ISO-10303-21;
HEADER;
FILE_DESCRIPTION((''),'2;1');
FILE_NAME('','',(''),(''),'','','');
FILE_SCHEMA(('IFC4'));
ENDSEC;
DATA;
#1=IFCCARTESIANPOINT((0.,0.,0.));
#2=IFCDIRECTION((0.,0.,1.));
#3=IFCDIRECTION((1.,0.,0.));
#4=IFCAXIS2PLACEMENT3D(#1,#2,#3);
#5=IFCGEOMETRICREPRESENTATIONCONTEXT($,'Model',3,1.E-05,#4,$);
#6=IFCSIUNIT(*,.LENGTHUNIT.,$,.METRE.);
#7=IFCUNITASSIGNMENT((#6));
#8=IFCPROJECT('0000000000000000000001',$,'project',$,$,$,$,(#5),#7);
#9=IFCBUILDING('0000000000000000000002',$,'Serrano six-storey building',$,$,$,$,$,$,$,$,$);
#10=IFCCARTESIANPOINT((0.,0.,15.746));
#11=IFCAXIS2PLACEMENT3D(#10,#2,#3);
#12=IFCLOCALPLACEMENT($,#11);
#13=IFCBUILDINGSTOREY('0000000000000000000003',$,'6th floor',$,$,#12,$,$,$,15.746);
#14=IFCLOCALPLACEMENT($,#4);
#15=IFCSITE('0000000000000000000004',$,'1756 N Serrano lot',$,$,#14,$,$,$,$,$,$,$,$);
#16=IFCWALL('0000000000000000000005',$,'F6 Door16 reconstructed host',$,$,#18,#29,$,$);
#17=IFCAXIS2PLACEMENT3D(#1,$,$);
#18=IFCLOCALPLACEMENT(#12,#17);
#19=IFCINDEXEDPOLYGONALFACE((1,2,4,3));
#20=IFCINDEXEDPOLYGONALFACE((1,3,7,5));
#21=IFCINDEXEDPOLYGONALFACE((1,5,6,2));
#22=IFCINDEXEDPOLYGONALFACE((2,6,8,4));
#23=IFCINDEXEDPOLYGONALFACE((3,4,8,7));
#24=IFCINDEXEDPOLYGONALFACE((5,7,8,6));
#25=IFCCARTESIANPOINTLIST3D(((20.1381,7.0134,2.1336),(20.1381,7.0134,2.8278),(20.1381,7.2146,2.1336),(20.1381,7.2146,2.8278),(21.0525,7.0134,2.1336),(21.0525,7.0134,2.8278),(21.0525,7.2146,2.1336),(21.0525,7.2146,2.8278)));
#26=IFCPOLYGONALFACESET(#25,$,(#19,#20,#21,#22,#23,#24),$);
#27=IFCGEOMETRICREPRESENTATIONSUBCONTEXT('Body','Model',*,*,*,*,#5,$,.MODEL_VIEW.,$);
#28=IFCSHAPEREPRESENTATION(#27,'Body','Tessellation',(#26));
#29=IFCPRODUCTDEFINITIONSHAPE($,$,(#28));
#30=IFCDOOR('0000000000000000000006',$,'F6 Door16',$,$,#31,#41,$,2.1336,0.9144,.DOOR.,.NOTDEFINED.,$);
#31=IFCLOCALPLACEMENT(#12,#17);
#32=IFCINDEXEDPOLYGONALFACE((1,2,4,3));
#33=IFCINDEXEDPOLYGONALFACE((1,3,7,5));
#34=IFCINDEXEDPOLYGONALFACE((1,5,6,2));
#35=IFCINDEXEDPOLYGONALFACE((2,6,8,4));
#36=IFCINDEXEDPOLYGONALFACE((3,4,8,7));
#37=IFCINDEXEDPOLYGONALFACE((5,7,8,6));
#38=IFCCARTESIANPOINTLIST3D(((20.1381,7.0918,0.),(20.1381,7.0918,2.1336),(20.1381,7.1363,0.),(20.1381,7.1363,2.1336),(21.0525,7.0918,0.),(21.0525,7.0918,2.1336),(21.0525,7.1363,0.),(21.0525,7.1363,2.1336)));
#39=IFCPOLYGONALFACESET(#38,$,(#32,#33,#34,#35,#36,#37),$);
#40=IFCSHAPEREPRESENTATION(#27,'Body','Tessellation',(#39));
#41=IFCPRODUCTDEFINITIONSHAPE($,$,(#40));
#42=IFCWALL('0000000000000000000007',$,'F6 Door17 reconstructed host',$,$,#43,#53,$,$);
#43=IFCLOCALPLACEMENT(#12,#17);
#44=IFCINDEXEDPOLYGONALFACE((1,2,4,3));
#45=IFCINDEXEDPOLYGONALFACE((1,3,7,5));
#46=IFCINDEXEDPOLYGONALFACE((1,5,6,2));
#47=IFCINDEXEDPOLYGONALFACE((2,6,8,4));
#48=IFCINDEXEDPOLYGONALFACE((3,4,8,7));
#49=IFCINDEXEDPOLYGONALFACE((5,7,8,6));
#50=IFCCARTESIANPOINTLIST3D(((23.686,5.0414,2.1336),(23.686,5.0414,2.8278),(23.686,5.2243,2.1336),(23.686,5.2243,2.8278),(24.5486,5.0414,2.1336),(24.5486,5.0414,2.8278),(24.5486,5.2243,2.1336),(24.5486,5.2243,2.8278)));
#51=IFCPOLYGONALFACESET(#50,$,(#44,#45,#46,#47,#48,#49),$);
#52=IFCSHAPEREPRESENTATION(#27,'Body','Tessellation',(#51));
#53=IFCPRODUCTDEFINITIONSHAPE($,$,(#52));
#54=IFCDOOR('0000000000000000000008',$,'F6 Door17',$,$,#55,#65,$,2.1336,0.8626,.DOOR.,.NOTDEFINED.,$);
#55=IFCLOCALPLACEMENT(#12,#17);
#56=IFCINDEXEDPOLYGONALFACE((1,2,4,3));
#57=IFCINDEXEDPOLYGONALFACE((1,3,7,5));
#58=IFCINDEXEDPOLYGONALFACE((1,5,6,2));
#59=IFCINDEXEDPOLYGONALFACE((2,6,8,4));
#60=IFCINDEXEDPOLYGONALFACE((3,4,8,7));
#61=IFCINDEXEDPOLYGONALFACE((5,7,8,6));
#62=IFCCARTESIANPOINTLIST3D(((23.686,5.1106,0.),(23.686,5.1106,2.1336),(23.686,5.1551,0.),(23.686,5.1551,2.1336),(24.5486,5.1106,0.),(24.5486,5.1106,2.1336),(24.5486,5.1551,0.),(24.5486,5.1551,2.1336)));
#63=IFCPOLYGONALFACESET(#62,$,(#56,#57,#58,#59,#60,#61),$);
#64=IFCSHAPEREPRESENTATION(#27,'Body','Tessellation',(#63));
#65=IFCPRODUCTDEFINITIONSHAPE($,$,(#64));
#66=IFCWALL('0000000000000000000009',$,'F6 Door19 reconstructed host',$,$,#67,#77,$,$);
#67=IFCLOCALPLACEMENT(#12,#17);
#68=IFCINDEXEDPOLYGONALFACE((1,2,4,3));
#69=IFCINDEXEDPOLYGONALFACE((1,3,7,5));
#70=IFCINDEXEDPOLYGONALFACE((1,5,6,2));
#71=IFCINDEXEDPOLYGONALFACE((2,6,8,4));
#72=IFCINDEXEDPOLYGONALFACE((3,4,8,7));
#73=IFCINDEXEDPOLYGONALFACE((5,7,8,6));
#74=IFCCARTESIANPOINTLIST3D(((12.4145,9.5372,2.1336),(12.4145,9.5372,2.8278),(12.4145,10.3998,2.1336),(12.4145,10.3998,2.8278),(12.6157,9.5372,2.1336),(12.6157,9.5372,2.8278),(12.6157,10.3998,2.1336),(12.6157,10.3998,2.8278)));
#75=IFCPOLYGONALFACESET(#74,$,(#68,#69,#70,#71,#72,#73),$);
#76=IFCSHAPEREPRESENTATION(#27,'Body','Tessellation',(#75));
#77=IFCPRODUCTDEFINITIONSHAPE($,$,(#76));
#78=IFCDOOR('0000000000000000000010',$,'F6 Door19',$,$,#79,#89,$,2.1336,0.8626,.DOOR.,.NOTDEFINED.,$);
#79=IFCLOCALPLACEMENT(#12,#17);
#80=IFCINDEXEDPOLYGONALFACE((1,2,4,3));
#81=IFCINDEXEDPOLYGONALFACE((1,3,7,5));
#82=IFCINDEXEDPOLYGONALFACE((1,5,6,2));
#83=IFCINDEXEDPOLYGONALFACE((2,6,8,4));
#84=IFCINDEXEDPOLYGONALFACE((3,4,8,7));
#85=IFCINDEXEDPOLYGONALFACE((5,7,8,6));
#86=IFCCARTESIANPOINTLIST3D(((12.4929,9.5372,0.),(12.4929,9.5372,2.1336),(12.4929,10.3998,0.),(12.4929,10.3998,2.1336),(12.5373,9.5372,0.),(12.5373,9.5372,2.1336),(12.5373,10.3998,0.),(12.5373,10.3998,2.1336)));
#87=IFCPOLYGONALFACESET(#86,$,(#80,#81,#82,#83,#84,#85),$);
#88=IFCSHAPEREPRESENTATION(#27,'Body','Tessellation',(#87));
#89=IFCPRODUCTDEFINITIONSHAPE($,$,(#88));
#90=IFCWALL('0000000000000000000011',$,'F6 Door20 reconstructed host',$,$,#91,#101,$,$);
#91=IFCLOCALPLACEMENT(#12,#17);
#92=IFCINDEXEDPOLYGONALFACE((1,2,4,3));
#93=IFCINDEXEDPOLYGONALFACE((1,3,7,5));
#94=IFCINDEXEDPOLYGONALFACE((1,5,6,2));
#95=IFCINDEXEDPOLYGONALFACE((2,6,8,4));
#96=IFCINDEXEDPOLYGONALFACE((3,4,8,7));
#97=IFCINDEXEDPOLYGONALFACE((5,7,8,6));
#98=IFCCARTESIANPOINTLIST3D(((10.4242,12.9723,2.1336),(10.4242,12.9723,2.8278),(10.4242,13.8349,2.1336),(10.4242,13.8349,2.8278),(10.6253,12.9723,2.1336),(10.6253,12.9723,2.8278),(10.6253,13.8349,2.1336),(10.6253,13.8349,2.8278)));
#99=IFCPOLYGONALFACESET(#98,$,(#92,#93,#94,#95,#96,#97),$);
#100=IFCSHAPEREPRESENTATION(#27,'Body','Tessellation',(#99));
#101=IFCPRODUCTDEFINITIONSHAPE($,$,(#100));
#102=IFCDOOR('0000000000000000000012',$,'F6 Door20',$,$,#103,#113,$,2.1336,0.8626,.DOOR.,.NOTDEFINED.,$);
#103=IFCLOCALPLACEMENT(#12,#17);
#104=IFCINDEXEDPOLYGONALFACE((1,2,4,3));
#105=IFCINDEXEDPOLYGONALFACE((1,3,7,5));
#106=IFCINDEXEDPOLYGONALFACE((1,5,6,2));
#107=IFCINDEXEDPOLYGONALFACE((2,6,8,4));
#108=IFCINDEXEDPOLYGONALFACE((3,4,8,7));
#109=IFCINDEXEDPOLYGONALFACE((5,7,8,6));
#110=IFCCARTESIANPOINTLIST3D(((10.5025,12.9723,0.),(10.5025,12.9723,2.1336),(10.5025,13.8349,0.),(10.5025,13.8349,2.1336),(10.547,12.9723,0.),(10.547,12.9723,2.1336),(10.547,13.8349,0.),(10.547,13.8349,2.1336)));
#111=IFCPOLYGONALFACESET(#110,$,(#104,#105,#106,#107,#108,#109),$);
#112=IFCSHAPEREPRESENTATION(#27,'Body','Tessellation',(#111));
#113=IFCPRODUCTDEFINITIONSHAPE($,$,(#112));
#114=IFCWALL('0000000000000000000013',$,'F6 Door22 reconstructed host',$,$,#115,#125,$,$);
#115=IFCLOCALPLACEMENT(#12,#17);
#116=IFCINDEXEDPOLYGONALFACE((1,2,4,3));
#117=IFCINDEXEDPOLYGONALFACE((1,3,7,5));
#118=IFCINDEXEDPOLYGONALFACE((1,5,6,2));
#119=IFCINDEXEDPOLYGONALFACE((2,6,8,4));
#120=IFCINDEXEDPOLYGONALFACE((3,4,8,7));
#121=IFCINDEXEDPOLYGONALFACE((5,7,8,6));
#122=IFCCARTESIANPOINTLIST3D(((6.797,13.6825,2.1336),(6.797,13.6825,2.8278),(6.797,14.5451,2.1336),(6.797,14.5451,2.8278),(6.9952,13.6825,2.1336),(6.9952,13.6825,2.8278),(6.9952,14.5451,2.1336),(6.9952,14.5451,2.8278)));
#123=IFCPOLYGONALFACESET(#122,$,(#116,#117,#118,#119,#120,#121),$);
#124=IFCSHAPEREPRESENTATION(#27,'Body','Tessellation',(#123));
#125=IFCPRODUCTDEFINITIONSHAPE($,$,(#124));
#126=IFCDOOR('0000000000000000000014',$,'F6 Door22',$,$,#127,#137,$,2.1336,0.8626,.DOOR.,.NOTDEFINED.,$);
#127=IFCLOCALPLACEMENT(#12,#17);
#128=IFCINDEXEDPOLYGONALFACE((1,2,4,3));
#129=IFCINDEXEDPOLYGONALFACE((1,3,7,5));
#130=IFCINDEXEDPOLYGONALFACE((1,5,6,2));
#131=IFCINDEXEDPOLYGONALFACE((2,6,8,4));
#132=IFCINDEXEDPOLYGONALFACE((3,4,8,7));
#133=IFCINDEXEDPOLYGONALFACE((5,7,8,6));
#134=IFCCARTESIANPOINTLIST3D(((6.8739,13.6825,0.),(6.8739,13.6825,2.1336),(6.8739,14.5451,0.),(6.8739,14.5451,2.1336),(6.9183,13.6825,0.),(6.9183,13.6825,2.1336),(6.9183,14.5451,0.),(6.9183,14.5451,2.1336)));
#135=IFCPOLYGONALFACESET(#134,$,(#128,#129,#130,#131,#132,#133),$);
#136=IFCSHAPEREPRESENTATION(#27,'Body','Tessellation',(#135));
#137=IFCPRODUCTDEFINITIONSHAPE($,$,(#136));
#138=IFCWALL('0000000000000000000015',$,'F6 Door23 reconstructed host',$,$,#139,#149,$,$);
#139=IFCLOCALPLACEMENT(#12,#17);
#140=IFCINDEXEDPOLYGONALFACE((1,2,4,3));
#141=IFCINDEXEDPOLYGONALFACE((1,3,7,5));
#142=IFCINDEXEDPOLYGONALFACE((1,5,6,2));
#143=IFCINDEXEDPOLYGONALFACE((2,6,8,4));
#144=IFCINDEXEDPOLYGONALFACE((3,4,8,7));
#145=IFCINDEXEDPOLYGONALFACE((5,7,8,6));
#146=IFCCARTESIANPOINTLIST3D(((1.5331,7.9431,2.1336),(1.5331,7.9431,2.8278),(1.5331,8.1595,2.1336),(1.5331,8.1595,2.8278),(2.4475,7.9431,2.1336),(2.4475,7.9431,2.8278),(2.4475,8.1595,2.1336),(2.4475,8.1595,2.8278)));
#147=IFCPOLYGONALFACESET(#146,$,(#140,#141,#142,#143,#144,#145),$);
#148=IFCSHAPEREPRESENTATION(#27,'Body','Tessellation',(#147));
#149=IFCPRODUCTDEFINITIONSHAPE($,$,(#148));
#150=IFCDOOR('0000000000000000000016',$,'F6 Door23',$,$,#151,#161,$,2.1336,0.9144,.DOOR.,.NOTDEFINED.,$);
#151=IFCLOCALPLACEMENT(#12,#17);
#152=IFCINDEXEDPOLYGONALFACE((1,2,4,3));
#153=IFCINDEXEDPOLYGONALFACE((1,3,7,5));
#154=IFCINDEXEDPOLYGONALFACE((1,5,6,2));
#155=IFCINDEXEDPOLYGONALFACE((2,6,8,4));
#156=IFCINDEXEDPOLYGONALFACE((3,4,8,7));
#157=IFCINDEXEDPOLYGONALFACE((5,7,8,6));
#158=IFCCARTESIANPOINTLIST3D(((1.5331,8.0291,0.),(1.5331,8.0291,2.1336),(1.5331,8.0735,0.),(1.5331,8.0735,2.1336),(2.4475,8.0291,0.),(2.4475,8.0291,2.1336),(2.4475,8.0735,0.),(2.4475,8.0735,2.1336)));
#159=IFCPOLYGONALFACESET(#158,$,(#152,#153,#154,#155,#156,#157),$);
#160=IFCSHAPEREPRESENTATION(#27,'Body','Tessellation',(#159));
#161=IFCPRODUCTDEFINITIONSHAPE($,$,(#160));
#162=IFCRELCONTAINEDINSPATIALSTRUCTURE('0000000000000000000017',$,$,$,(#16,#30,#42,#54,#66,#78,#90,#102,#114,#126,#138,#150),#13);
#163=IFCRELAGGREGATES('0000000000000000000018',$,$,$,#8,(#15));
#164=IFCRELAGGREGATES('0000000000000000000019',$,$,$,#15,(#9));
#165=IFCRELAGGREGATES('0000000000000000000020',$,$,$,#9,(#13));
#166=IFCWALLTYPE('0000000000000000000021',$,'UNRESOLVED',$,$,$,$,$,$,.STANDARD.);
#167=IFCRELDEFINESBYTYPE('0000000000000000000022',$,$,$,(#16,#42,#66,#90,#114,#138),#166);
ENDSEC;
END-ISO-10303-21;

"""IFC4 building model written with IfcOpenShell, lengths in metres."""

from ifc_helpers import new_model, si_unit, frame, origin_with_axes, place, context, subcontext, project, spatial, polyline, outline, extrude, type_object, element, fill, save


model = new_model("IFC4")

# Units and contexts
model_context = context("Model", 3, precision=1e-05, world=origin_with_axes())
body_context = subcontext(model_context, "Body", "Model", "MODEL_VIEW")
ifc_project = project(units=[si_unit("LENGTHUNIT", "METRE")], contexts=[model_context])

# Site, building, storey
site_placement = place(None, origin_with_axes())
site = spatial("IfcSite", under=ifc_project, at=site_placement, Name="1756 N Serrano lot")
building = spatial("IfcBuilding", under=site, Name="Serrano six-storey building")
storey_placement = place(None, frame((0.0, 0.0, 15.746), z_axis=(0.0, 0.0, 1.0), x_axis=(1.0, 0.0, 0.0)))
storey = spatial("IfcBuildingStorey", under=building, at=storey_placement, Name="6th floor", Elevation=15.746)

# Walls, openings, doors
wall_type_1 = type_object("IfcWallType", Name="UNRESOLVED", PredefinedType="STANDARD")
wall_1_placement = place(storey_placement, frame((0.0, 0.0, -15.746), z_axis=(0.0, 0.0, 1.0), x_axis=(1.0, 0.0, 0.0)))
wall_1 = element("IfcWall", 1, at=wall_1_placement, inside=storey, type_object=wall_type_1, Name="F6 Door16 reconstructed host", context=body_context, shape_type="SweptSolid", body=[
    extrude(outline(polyline([(21.0525, 7.2146), (21.0525, 7.0134), (20.1381, 7.0134), (20.1381, 7.2146), (21.0525, 7.2146)])), frame((0.0, 0.0, 15.746)), (0.0, 0.0, 1.0), 2.8278),
])
opening_1_placement = place(None, origin_with_axes())
opening_1 = element("IfcOpeningElement", 2, at=opening_1_placement, cuts=wall_1, PredefinedType="OPENING", context=body_context, shape_type="SweptSolid", body=[
    extrude(outline(polyline([(21.0525, 7.2329), (21.0525, 6.9952), (20.1381, 6.9952), (20.1381, 7.2329), (21.0525, 7.2329)])), frame((0.0, 0.0, 15.746)), (0.0, 0.0, 1.0), 2.1336),
])
door_1_placement = place(storey_placement, frame((0.0, 0.0, -15.746), z_axis=(0.0, 0.0, 1.0), x_axis=(1.0, 0.0, 0.0)))
door_1 = element("IfcDoor", 3, at=door_1_placement, inside=storey, Name="F6 Door16", OperationType="NOTDEFINED", OverallHeight=2.1336, OverallWidth=0.9144, PredefinedType="DOOR", context=body_context, shape_type="SweptSolid", body=[
    extrude(outline(polyline([(21.0525, 7.1363), (21.0525, 7.0918), (20.1381, 7.0918), (20.1381, 7.1363), (21.0525, 7.1363)])), frame((0.0, 0.0, 15.746)), (0.0, 0.0, 1.0), 2.1336),
])
fill(opening_1, door_1)
wall_2_placement = place(storey_placement, frame((0.0, 0.0, -15.746), z_axis=(0.0, 0.0, 1.0), x_axis=(1.0, 0.0, 0.0)))
wall_2 = element("IfcWall", 4, at=wall_2_placement, inside=storey, type_object=wall_type_1, Name="F6 Door17 reconstructed host", context=body_context, shape_type="SweptSolid", body=[
    extrude(outline(polyline([(23.686, 5.0414), (23.686, 5.2243), (24.5486, 5.2243), (24.5486, 5.0414), (23.686, 5.0414)])), frame((0.0, 0.0, 15.746)), (0.0, 0.0, 1.0), 2.8278),
])
opening_2_placement = place(None, origin_with_axes())
opening_2 = element("IfcOpeningElement", 5, at=opening_2_placement, cuts=wall_2, PredefinedType="OPENING", context=body_context, shape_type="SweptSolid", body=[
    extrude(outline(polyline([(23.686, 5.0231), (23.686, 5.2426), (24.5486, 5.2426), (24.5486, 5.0231), (23.686, 5.0231)])), frame((0.0, 0.0, 15.746)), (0.0, 0.0, 1.0), 2.1336),
])
door_2_placement = place(storey_placement, frame((0.0, 0.0, -15.746), z_axis=(0.0, 0.0, 1.0), x_axis=(1.0, 0.0, 0.0)))
door_2 = element("IfcDoor", 6, at=door_2_placement, inside=storey, Name="F6 Door17", OperationType="NOTDEFINED", OverallHeight=2.1336, OverallWidth=0.8626, PredefinedType="DOOR", context=body_context, shape_type="SweptSolid", body=[
    extrude(outline(polyline([(23.686, 5.1106), (23.686, 5.1551), (24.5486, 5.1551), (24.5486, 5.1106), (23.686, 5.1106)])), frame((0.0, 0.0, 15.746)), (0.0, 0.0, 1.0), 2.1336),
])
fill(opening_2, door_2)
wall_3_placement = place(storey_placement, frame((0.0, 0.0, -15.746), z_axis=(0.0, 0.0, 1.0), x_axis=(1.0, 0.0, 0.0)))
wall_3 = element("IfcWall", 7, at=wall_3_placement, inside=storey, type_object=wall_type_1, Name="F6 Door19 reconstructed host", context=body_context, shape_type="SweptSolid", body=[
    extrude(outline(polyline([(12.4145, 10.3998), (12.6157, 10.3998), (12.6157, 9.5372), (12.4145, 9.5372), (12.4145, 10.3998)])), frame((0.0, 0.0, 15.746)), (0.0, 0.0, 1.0), 2.8278),
])
opening_3_placement = place(None, origin_with_axes())
opening_3 = element("IfcOpeningElement", 8, at=opening_3_placement, cuts=wall_3, PredefinedType="OPENING", context=body_context, shape_type="SweptSolid", body=[
    extrude(outline(polyline([(12.3962, 10.3998), (12.634, 10.3998), (12.634, 9.5372), (12.3962, 9.5372), (12.3962, 10.3998)])), frame((0.0, 0.0, 15.746)), (0.0, 0.0, 1.0), 2.1336),
])
door_3_placement = place(storey_placement, frame((0.0, 0.0, -15.746), z_axis=(0.0, 0.0, 1.0), x_axis=(1.0, 0.0, 0.0)))
door_3 = element("IfcDoor", 9, at=door_3_placement, inside=storey, Name="F6 Door19", OperationType="NOTDEFINED", OverallHeight=2.1336, OverallWidth=0.8626, PredefinedType="DOOR", context=body_context, shape_type="SweptSolid", body=[
    extrude(outline(polyline([(12.4929, 10.3998), (12.5373, 10.3998), (12.5373, 9.5372), (12.4929, 9.5372), (12.4929, 10.3998)])), frame((0.0, 0.0, 15.746)), (0.0, 0.0, 1.0), 2.1336),
])
fill(opening_3, door_3)
wall_4_placement = place(storey_placement, frame((0.0, 0.0, -15.746), z_axis=(0.0, 0.0, 1.0), x_axis=(1.0, 0.0, 0.0)))
wall_4 = element("IfcWall", 10, at=wall_4_placement, inside=storey, type_object=wall_type_1, Name="F6 Door20 reconstructed host", context=body_context, shape_type="SweptSolid", body=[
    extrude(outline(polyline([(10.6253, 12.9723), (10.4242, 12.9723), (10.4242, 13.8349), (10.6253, 13.8349), (10.6253, 12.9723)])), frame((0.0, 0.0, 15.746)), (0.0, 0.0, 1.0), 2.8278),
])
opening_4_placement = place(None, origin_with_axes())
opening_4 = element("IfcOpeningElement", 11, at=opening_4_placement, cuts=wall_4, PredefinedType="OPENING", context=body_context, shape_type="SweptSolid", body=[
    extrude(outline(polyline([(10.6436, 12.9723), (10.4059, 12.9723), (10.4059, 13.8349), (10.6436, 13.8349), (10.6436, 12.9723)])), frame((0.0, 0.0, 15.746)), (0.0, 0.0, 1.0), 2.1336),
])
door_4_placement = place(storey_placement, frame((0.0, 0.0, -15.746), z_axis=(0.0, 0.0, 1.0), x_axis=(1.0, 0.0, 0.0)))
door_4 = element("IfcDoor", 12, at=door_4_placement, inside=storey, Name="F6 Door20", OperationType="NOTDEFINED", OverallHeight=2.1336, OverallWidth=0.8626, PredefinedType="DOOR", context=body_context, shape_type="SweptSolid", body=[
    extrude(outline(polyline([(10.547, 12.9723), (10.5025, 12.9723), (10.5025, 13.8349), (10.547, 13.8349), (10.547, 12.9723)])), frame((0.0, 0.0, 15.746)), (0.0, 0.0, 1.0), 2.1336),
])
fill(opening_4, door_4)
wall_5_placement = place(storey_placement, frame((0.0, 0.0, -15.746), z_axis=(0.0, 0.0, 1.0), x_axis=(1.0, 0.0, 0.0)))
wall_5 = element("IfcWall", 13, at=wall_5_placement, inside=storey, type_object=wall_type_1, Name="F6 Door22 reconstructed host", context=body_context, shape_type="SweptSolid", body=[
    extrude(outline(polyline([(6.9952, 13.6825), (6.797, 13.6825), (6.797, 14.5451), (6.9952, 14.5451), (6.9952, 13.6825)])), frame((0.0, 0.0, 15.746)), (0.0, 0.0, 1.0), 2.8278),
])
opening_5_placement = place(None, origin_with_axes())
opening_5 = element("IfcOpeningElement", 14, at=opening_5_placement, cuts=wall_5, PredefinedType="OPENING", context=body_context, shape_type="SweptSolid", body=[
    extrude(outline(polyline([(7.0134, 13.6825), (6.7788, 13.6825), (6.7788, 14.5451), (7.0134, 14.5451), (7.0134, 13.6825)])), frame((0.0, 0.0, 15.746)), (0.0, 0.0, 1.0), 2.1336),
])
door_5_placement = place(storey_placement, frame((0.0, 0.0, -15.746), z_axis=(0.0, 0.0, 1.0), x_axis=(1.0, 0.0, 0.0)))
door_5 = element("IfcDoor", 15, at=door_5_placement, inside=storey, Name="F6 Door22", OperationType="NOTDEFINED", OverallHeight=2.1336, OverallWidth=0.8626, PredefinedType="DOOR", context=body_context, shape_type="SweptSolid", body=[
    extrude(outline(polyline([(6.9183, 13.6825), (6.8739, 13.6825), (6.8739, 14.5451), (6.9183, 14.5451), (6.9183, 13.6825)])), frame((0.0, 0.0, 15.746)), (0.0, 0.0, 1.0), 2.1336),
])
fill(opening_5, door_5)
wall_6_placement = place(storey_placement, frame((0.0, 0.0, -15.746), z_axis=(0.0, 0.0, 1.0), x_axis=(1.0, 0.0, 0.0)))
wall_6 = element("IfcWall", 16, at=wall_6_placement, inside=storey, type_object=wall_type_1, Name="F6 Door23 reconstructed host", context=body_context, shape_type="SweptSolid", body=[
    extrude(outline(polyline([(2.4475, 8.1595), (2.4475, 7.9431), (1.5331, 7.9431), (1.5331, 8.1595), (2.4475, 8.1595)])), frame((0.0, 0.0, 15.746)), (0.0, 0.0, 1.0), 2.8278),
])
opening_6_placement = place(None, origin_with_axes())
opening_6 = element("IfcOpeningElement", 17, at=opening_6_placement, cuts=wall_6, PredefinedType="OPENING", context=body_context, shape_type="SweptSolid", body=[
    extrude(outline(polyline([(2.4475, 8.1778), (2.4475, 7.9248), (1.5331, 7.9248), (1.5331, 8.1778), (2.4475, 8.1778)])), frame((0.0, 0.0, 15.746)), (0.0, 0.0, 1.0), 2.1336),
])
door_6_placement = place(storey_placement, frame((0.0, 0.0, -15.746), z_axis=(0.0, 0.0, 1.0), x_axis=(1.0, 0.0, 0.0)))
door_6 = element("IfcDoor", 18, at=door_6_placement, inside=storey, Name="F6 Door23", OperationType="NOTDEFINED", OverallHeight=2.1336, OverallWidth=0.9144, PredefinedType="DOOR", context=body_context, shape_type="SweptSolid", body=[
    extrude(outline(polyline([(2.4475, 8.0735), (2.4475, 8.0291), (1.5331, 8.0291), (1.5331, 8.0735), (2.4475, 8.0735)])), frame((0.0, 0.0, 15.746)), (0.0, 0.0, 1.0), 2.1336),
])
fill(opening_6, door_6)

save(model, "model.ifc")
